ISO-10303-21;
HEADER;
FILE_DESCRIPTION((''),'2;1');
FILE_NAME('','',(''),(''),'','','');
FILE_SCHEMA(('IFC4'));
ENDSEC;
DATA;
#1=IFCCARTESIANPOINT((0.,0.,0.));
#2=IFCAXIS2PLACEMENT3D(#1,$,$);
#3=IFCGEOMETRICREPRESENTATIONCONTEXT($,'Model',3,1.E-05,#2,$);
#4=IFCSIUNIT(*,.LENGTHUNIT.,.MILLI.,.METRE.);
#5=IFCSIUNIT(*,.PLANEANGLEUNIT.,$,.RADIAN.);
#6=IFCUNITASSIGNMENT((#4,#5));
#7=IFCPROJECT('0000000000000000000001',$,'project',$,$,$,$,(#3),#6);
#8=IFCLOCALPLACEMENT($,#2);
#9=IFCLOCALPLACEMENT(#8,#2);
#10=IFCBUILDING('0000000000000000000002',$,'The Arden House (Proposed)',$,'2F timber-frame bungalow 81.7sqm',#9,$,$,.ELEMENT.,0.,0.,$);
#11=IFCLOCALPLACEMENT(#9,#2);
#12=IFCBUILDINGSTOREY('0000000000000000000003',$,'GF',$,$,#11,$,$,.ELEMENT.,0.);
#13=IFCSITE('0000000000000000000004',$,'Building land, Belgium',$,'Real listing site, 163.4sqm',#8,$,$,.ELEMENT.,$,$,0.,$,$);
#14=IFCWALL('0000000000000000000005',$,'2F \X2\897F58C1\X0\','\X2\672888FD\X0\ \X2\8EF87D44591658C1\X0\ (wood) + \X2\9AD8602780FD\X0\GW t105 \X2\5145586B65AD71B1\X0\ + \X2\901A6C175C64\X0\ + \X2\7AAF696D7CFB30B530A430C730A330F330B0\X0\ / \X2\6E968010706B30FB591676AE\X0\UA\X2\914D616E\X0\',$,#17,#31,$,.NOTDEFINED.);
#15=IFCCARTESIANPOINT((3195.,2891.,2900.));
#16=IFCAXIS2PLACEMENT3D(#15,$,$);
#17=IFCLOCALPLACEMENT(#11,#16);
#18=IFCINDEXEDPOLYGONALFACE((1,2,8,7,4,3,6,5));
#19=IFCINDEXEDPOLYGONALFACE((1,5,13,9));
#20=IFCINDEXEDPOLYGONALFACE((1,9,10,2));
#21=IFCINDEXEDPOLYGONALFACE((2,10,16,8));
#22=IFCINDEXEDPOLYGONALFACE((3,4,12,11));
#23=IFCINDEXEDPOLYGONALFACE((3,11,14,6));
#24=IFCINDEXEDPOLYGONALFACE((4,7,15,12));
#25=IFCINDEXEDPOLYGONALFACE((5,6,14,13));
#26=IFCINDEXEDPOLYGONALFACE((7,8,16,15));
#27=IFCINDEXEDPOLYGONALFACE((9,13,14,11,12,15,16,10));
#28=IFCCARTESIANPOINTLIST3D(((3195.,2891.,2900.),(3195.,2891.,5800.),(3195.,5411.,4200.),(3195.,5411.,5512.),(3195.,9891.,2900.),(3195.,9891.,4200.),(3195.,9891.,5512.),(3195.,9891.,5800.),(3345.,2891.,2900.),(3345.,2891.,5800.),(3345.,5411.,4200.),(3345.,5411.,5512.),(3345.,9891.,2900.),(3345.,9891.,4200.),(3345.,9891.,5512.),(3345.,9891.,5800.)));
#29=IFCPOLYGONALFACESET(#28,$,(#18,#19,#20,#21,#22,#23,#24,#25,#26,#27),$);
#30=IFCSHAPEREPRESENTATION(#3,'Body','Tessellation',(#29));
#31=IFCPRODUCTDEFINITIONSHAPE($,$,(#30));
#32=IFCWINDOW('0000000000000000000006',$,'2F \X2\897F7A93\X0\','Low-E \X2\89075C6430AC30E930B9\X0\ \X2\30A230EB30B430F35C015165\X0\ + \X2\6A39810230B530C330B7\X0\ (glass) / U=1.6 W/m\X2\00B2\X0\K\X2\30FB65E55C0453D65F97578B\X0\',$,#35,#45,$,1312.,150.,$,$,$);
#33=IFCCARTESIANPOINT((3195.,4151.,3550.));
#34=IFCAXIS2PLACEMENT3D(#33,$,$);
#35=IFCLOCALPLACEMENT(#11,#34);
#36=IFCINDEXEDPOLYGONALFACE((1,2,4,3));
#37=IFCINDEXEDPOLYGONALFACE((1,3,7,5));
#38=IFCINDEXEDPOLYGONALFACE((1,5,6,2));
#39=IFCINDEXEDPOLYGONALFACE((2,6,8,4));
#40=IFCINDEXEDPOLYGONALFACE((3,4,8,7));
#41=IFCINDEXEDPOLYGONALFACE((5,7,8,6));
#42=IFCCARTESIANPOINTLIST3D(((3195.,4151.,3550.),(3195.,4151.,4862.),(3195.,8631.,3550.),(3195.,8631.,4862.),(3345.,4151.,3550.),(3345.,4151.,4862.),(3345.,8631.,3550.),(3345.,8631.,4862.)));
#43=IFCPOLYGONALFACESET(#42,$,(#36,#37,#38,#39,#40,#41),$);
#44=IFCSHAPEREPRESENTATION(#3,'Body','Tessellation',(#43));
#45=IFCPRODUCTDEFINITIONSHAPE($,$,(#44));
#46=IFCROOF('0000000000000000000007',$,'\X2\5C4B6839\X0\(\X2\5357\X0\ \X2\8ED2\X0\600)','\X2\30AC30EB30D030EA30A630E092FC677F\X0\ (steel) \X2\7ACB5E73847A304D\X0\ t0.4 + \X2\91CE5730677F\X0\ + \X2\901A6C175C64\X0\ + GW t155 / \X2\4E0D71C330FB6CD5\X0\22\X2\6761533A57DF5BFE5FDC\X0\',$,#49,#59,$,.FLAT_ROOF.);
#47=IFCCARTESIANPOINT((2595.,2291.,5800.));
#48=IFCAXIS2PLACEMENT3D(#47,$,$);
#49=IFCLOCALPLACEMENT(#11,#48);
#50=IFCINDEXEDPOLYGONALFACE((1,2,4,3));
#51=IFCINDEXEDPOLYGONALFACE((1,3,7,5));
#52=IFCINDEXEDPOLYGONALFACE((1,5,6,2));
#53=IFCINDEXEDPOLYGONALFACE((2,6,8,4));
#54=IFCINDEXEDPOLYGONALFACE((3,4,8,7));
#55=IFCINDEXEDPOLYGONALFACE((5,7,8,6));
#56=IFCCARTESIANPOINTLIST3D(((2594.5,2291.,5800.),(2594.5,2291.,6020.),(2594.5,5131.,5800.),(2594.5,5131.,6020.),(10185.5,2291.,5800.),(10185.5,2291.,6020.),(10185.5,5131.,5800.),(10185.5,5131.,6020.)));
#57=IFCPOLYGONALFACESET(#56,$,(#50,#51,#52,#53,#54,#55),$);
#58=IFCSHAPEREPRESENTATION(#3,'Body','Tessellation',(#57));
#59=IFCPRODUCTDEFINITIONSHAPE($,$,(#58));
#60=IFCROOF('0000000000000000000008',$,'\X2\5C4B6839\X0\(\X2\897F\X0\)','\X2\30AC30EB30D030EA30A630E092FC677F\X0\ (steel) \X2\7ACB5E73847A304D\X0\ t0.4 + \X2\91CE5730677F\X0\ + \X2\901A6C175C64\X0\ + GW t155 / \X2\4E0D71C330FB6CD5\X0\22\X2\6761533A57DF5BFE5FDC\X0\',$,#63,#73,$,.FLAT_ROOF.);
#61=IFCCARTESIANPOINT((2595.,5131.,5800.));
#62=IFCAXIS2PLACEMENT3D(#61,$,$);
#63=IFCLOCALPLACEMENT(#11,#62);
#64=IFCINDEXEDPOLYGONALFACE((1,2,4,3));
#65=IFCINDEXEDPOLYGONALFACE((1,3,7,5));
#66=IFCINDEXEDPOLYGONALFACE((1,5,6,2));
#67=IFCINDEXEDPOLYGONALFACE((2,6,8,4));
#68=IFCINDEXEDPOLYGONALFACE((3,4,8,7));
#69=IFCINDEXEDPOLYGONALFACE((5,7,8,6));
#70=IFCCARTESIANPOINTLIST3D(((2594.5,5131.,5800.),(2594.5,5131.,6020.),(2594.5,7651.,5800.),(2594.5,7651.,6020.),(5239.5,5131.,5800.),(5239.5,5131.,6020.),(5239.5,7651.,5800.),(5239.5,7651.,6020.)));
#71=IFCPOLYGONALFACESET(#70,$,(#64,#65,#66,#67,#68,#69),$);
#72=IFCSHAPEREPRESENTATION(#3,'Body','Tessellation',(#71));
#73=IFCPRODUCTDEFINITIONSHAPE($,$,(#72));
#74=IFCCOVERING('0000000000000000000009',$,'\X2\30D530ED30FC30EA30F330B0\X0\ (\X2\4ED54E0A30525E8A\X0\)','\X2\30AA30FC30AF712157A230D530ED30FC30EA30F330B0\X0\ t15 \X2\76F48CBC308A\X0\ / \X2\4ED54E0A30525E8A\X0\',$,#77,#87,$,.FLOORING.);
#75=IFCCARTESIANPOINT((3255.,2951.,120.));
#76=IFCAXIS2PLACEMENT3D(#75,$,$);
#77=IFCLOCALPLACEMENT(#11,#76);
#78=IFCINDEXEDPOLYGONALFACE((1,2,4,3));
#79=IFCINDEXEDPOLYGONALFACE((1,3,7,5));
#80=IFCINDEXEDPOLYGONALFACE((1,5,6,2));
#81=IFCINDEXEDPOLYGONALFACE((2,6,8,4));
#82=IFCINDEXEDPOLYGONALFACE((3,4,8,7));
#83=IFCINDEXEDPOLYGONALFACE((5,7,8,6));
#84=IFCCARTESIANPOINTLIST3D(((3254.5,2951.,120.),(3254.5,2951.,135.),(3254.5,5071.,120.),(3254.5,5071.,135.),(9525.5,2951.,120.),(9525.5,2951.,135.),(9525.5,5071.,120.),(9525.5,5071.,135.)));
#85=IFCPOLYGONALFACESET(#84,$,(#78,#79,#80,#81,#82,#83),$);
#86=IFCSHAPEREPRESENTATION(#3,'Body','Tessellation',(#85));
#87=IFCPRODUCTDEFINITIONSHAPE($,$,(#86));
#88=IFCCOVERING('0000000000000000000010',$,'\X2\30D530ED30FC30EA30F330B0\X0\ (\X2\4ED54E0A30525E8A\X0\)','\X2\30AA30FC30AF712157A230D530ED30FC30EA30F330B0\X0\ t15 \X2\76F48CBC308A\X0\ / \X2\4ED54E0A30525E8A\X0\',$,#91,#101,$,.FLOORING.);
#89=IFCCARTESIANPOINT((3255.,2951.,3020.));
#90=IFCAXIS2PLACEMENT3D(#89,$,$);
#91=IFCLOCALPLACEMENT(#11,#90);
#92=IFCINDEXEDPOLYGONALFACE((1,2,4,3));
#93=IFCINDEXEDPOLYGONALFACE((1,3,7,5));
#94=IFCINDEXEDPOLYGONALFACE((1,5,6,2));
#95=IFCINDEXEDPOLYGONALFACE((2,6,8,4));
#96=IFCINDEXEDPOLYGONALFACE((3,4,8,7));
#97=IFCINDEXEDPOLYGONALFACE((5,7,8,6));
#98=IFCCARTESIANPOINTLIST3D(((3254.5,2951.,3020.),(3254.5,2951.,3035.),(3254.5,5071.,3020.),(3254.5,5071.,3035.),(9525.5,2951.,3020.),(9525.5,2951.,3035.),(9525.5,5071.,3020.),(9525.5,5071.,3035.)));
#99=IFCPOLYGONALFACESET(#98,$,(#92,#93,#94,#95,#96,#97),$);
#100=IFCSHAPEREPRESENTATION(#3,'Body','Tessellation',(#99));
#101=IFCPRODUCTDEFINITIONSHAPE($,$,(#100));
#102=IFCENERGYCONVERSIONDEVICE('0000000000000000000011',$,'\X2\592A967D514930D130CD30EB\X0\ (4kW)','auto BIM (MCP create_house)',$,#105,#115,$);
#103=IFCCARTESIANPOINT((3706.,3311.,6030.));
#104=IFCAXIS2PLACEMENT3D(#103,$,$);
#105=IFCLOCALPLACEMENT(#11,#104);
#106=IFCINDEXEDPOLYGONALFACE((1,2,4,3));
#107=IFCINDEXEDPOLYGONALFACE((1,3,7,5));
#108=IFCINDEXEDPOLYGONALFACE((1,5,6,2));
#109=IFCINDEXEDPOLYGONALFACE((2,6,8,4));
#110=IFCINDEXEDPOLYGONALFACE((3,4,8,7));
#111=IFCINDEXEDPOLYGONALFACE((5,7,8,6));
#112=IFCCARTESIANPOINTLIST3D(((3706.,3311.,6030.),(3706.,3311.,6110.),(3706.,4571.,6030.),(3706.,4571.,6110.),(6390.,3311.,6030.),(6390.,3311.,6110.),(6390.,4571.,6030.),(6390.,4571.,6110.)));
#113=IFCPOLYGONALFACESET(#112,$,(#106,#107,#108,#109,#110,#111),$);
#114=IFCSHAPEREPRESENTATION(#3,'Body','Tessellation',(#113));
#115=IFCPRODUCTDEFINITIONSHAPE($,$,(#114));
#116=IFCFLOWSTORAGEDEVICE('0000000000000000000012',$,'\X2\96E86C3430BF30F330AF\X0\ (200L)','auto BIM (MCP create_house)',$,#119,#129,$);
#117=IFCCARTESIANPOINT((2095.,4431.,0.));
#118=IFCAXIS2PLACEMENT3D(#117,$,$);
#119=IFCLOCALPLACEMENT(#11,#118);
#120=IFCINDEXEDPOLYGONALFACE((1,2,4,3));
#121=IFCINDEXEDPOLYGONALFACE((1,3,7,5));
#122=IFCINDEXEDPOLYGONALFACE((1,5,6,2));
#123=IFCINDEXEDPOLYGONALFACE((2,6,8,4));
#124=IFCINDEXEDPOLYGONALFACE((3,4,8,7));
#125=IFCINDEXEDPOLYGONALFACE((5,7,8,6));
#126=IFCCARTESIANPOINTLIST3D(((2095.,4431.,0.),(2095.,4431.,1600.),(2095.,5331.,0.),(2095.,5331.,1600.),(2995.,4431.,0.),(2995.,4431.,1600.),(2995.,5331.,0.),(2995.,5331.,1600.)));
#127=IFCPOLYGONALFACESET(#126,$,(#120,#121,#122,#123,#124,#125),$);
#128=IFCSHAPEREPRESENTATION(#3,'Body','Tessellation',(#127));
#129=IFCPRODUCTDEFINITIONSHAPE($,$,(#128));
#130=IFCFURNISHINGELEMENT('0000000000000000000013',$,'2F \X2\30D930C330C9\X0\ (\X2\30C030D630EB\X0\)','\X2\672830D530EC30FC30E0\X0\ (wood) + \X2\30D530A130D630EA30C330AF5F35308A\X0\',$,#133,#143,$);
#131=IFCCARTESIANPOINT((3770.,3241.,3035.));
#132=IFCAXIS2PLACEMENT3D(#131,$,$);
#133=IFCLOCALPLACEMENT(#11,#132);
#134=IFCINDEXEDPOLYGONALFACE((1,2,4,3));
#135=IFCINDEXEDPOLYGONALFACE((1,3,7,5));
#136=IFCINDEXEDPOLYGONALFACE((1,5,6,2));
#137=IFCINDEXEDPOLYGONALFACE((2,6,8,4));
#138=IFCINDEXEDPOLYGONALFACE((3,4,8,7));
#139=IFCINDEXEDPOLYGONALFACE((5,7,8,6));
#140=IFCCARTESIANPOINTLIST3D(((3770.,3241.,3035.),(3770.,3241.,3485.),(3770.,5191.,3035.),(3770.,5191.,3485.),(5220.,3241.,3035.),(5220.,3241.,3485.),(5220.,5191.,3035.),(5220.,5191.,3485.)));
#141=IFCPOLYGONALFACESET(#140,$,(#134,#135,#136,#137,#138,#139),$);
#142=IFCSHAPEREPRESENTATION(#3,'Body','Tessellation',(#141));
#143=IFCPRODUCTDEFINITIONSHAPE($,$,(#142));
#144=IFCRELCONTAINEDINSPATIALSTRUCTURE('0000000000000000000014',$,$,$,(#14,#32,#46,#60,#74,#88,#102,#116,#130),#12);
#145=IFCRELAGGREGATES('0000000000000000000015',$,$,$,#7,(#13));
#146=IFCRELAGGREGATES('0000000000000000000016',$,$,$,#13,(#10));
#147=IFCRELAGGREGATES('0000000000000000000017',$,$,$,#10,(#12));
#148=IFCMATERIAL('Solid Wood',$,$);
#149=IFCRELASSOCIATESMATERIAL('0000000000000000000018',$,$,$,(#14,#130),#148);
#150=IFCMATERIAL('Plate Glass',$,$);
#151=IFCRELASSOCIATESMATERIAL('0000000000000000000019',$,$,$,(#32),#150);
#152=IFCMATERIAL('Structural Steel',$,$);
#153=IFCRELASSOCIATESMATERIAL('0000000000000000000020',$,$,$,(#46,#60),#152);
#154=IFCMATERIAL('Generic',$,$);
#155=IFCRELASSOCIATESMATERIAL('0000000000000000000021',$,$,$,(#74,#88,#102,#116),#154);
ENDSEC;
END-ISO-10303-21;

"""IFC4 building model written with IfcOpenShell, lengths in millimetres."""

from ifc_helpers import new_model, si_unit, frame, frame_2d, origin, place, context, project, spatial, rectangle, extrude, material, element, fill, save


model = new_model("IFC4")

# Units and contexts
model_context = context("Model", 3, precision=1e-05, world=origin())
ifc_project = project(units=[si_unit("LENGTHUNIT", "METRE", prefix="MILLI"), si_unit("PLANEANGLEUNIT", "RADIAN")], contexts=[model_context])

# Site, building, storey
site_placement = place(None, origin())
site = spatial("IfcSite", under=ifc_project, at=site_placement, Name="Building land, Belgium", ObjectType="Real listing site, 163.4sqm", CompositionType="ELEMENT", RefElevation=0.0)
building_placement = place(site_placement, origin())
building = spatial("IfcBuilding", under=site, at=building_placement, Name="The Arden House (Proposed)", ObjectType="2F timber-frame bungalow 81.7sqm", CompositionType="ELEMENT", ElevationOfRefHeight=0.0, ElevationOfTerrain=0.0)
storey_placement = place(building_placement, origin())
storey = spatial("IfcBuildingStorey", under=building, at=storey_placement, Name="GF", CompositionType="ELEMENT", Elevation=0.0)

# Shared definitions
ifc_material_1 = material(Name="Solid Wood")

# Shared definitions
ifc_material_2 = material(Name="Plate Glass")

# Wall, opening, window
wall_1_placement = place(storey_placement, frame((3195.0, 2891.0, 2900.0)))
wall_1 = element("IfcWall", 1, at=wall_1_placement, inside=storey, material=ifc_material_1, Name="2F 西壁", Description="木製 軸組外壁 (wood) + 高性能GW t105 充填断熱 + 通気層 + 窯業系サイディング / 準耐火・外皮UA配慮", PredefinedType="NOTDEFINED", context=model_context, shape_type="SweptSolid", body=[
    extrude(rectangle(XDim=150.0, YDim=7000.0, at=frame_2d((75.0, 3500.0))), frame((3195.0, 2891.0, 2900.0)), (0.0, 0.0, 1.0), 2900.0),
])
opening_1_placement = place(storey_placement, frame((3195.0, 4151.0, 3550.0)))
opening_1 = element("IfcOpeningElement", 2, at=opening_1_placement, cuts=wall_1, PredefinedType="NOTDEFINED", context=model_context, shape_type="SweptSolid", body=[
    extrude(rectangle(XDim=150.0, YDim=4480.0, at=frame_2d((75.0, 2240.0))), frame((3195.0, 4151.0, 3550.0)), (0.0, 0.0, 1.0), 1312.0),
])
window_1_placement = place(storey_placement, frame((3195.0, 4151.0, 3550.0)))
window_1 = element("IfcWindow", 3, at=window_1_placement, inside=storey, material=ifc_material_2, Name="2F 西窓", Description="Low-E 複層ガラス アルゴン封入 + 樹脂サッシ (glass) / U=1.6 W/m²K・日射取得型", OverallHeight=1312.0, OverallWidth=150.0, context=model_context, shape_type="SweptSolid", body=[
    extrude(rectangle(XDim=150.0, YDim=4480.0, at=frame_2d((75.0, 2240.0))), frame((3195.0, 4151.0, 3550.0)), (0.0, 0.0, 1.0), 1312.0),
])
fill(opening_1, window_1)

# Roofs
ifc_material_3 = material(Name="Structural Steel")
roof_1_placement = place(storey_placement, frame((2595.0, 2291.0, 5800.0)))
element("IfcRoof", 4, at=roof_1_placement, inside=storey, material=ifc_material_3, Name="屋根(南 軒600)", Description="ガルバリウム鋼板 (steel) 立平葺き t0.4 + 野地板 + 通気層 + GW t155 / 不燃・法22条区域対応", PredefinedType="FLAT_ROOF", context=model_context, shape_type="SweptSolid", body=[
    extrude(rectangle(XDim=7591.0, YDim=2840.0, at=frame_2d((3795.0, 1420.0))), frame((2595.0, 2291.0, 5800.0)), (0.0, 0.0, 1.0), 220.0),
])
roof_2_placement = place(storey_placement, frame((2595.0, 5131.0, 5800.0)))
element("IfcRoof", 5, at=roof_2_placement, inside=storey, material=ifc_material_3, Name="屋根(西)", Description="ガルバリウム鋼板 (steel) 立平葺き t0.4 + 野地板 + 通気層 + GW t155 / 不燃・法22条区域対応", PredefinedType="FLAT_ROOF", context=model_context, shape_type="SweptSolid", body=[
    extrude(rectangle(XDim=2645.0, YDim=2520.0, at=frame_2d((1322.0, 1260.0))), frame((2595.0, 5131.0, 5800.0)), (0.0, 0.0, 1.0), 220.0),
])

# Coverings
ifc_material_4 = material(Name="Generic")
covering_1_placement = place(storey_placement, frame((3255.0, 2951.0, 120.0)))
element("IfcCovering", 6, at=covering_1_placement, inside=storey, material=ifc_material_4, Name="フローリング (仕上げ床)", Description="オーク無垢フローリング t15 直貼り / 仕上げ床", PredefinedType="FLOORING", context=model_context, shape_type="SweptSolid", body=[
    extrude(rectangle(XDim=6271.0, YDim=2120.0, at=frame_2d((3135.0, 1060.0))), frame((3255.0, 2951.0, 120.0)), (0.0, 0.0, 1.0), 15.0),
])
covering_2_placement = place(storey_placement, frame((3255.0, 2951.0, 3020.0)))
element("IfcCovering", 7, at=covering_2_placement, inside=storey, material=ifc_material_4, Name="フローリング (仕上げ床)", Description="オーク無垢フローリング t15 直貼り / 仕上げ床", PredefinedType="FLOORING", context=model_context, shape_type="SweptSolid", body=[
    extrude(rectangle(XDim=6271.0, YDim=2120.0, at=frame_2d((3135.0, 1060.0))), frame((3255.0, 2951.0, 3020.0)), (0.0, 0.0, 1.0), 15.0),
])

# Energy conversion device
energy_conversion_device_placement = place(storey_placement, frame((3706.0, 3311.0, 6030.0)))
element("IfcEnergyConversionDevice", 8, at=energy_conversion_device_placement, inside=storey, material=ifc_material_4, Name="太陽光パネル (4kW)", Description="auto BIM (MCP create_house)", context=model_context, shape_type="SweptSolid", body=[
    extrude(rectangle(XDim=2684.0, YDim=1260.0, at=frame_2d((1342.0, 630.0))), frame((3706.0, 3311.0, 6030.0)), (0.0, 0.0, 1.0), 80.0),
])

# Flow storage device
flow_storage_device_placement = place(storey_placement, frame((2095.0, 4431.0, 0.0)))
element("IfcFlowStorageDevice", 9, at=flow_storage_device_placement, inside=storey, material=ifc_material_4, Name="雨水タンク (200L)", Description="auto BIM (MCP create_house)", context=model_context, shape_type="SweptSolid", body=[
    extrude(rectangle(XDim=900.0, YDim=900.0, at=frame_2d((450.0, 450.0))), frame((2095.0, 4431.0, 0.0)), (0.0, 0.0, 1.0), 1600.0),
])

# Furnishing element
furnishing_placement = place(storey_placement, frame((3770.0, 3241.0, 3035.0)))
element("IfcFurnishingElement", 10, at=furnishing_placement, inside=storey, material=ifc_material_1, Name="2F ベッド (ダブル)", Description="木フレーム (wood) + ファブリック張り", context=model_context, shape_type="SweptSolid", body=[
    extrude(rectangle(XDim=1450.0, YDim=1950.0, at=frame_2d((725.0, 975.0))), frame((3770.0, 3241.0, 3035.0)), (0.0, 0.0, 1.0), 450.0),
])

save(model, "model.ifc")
